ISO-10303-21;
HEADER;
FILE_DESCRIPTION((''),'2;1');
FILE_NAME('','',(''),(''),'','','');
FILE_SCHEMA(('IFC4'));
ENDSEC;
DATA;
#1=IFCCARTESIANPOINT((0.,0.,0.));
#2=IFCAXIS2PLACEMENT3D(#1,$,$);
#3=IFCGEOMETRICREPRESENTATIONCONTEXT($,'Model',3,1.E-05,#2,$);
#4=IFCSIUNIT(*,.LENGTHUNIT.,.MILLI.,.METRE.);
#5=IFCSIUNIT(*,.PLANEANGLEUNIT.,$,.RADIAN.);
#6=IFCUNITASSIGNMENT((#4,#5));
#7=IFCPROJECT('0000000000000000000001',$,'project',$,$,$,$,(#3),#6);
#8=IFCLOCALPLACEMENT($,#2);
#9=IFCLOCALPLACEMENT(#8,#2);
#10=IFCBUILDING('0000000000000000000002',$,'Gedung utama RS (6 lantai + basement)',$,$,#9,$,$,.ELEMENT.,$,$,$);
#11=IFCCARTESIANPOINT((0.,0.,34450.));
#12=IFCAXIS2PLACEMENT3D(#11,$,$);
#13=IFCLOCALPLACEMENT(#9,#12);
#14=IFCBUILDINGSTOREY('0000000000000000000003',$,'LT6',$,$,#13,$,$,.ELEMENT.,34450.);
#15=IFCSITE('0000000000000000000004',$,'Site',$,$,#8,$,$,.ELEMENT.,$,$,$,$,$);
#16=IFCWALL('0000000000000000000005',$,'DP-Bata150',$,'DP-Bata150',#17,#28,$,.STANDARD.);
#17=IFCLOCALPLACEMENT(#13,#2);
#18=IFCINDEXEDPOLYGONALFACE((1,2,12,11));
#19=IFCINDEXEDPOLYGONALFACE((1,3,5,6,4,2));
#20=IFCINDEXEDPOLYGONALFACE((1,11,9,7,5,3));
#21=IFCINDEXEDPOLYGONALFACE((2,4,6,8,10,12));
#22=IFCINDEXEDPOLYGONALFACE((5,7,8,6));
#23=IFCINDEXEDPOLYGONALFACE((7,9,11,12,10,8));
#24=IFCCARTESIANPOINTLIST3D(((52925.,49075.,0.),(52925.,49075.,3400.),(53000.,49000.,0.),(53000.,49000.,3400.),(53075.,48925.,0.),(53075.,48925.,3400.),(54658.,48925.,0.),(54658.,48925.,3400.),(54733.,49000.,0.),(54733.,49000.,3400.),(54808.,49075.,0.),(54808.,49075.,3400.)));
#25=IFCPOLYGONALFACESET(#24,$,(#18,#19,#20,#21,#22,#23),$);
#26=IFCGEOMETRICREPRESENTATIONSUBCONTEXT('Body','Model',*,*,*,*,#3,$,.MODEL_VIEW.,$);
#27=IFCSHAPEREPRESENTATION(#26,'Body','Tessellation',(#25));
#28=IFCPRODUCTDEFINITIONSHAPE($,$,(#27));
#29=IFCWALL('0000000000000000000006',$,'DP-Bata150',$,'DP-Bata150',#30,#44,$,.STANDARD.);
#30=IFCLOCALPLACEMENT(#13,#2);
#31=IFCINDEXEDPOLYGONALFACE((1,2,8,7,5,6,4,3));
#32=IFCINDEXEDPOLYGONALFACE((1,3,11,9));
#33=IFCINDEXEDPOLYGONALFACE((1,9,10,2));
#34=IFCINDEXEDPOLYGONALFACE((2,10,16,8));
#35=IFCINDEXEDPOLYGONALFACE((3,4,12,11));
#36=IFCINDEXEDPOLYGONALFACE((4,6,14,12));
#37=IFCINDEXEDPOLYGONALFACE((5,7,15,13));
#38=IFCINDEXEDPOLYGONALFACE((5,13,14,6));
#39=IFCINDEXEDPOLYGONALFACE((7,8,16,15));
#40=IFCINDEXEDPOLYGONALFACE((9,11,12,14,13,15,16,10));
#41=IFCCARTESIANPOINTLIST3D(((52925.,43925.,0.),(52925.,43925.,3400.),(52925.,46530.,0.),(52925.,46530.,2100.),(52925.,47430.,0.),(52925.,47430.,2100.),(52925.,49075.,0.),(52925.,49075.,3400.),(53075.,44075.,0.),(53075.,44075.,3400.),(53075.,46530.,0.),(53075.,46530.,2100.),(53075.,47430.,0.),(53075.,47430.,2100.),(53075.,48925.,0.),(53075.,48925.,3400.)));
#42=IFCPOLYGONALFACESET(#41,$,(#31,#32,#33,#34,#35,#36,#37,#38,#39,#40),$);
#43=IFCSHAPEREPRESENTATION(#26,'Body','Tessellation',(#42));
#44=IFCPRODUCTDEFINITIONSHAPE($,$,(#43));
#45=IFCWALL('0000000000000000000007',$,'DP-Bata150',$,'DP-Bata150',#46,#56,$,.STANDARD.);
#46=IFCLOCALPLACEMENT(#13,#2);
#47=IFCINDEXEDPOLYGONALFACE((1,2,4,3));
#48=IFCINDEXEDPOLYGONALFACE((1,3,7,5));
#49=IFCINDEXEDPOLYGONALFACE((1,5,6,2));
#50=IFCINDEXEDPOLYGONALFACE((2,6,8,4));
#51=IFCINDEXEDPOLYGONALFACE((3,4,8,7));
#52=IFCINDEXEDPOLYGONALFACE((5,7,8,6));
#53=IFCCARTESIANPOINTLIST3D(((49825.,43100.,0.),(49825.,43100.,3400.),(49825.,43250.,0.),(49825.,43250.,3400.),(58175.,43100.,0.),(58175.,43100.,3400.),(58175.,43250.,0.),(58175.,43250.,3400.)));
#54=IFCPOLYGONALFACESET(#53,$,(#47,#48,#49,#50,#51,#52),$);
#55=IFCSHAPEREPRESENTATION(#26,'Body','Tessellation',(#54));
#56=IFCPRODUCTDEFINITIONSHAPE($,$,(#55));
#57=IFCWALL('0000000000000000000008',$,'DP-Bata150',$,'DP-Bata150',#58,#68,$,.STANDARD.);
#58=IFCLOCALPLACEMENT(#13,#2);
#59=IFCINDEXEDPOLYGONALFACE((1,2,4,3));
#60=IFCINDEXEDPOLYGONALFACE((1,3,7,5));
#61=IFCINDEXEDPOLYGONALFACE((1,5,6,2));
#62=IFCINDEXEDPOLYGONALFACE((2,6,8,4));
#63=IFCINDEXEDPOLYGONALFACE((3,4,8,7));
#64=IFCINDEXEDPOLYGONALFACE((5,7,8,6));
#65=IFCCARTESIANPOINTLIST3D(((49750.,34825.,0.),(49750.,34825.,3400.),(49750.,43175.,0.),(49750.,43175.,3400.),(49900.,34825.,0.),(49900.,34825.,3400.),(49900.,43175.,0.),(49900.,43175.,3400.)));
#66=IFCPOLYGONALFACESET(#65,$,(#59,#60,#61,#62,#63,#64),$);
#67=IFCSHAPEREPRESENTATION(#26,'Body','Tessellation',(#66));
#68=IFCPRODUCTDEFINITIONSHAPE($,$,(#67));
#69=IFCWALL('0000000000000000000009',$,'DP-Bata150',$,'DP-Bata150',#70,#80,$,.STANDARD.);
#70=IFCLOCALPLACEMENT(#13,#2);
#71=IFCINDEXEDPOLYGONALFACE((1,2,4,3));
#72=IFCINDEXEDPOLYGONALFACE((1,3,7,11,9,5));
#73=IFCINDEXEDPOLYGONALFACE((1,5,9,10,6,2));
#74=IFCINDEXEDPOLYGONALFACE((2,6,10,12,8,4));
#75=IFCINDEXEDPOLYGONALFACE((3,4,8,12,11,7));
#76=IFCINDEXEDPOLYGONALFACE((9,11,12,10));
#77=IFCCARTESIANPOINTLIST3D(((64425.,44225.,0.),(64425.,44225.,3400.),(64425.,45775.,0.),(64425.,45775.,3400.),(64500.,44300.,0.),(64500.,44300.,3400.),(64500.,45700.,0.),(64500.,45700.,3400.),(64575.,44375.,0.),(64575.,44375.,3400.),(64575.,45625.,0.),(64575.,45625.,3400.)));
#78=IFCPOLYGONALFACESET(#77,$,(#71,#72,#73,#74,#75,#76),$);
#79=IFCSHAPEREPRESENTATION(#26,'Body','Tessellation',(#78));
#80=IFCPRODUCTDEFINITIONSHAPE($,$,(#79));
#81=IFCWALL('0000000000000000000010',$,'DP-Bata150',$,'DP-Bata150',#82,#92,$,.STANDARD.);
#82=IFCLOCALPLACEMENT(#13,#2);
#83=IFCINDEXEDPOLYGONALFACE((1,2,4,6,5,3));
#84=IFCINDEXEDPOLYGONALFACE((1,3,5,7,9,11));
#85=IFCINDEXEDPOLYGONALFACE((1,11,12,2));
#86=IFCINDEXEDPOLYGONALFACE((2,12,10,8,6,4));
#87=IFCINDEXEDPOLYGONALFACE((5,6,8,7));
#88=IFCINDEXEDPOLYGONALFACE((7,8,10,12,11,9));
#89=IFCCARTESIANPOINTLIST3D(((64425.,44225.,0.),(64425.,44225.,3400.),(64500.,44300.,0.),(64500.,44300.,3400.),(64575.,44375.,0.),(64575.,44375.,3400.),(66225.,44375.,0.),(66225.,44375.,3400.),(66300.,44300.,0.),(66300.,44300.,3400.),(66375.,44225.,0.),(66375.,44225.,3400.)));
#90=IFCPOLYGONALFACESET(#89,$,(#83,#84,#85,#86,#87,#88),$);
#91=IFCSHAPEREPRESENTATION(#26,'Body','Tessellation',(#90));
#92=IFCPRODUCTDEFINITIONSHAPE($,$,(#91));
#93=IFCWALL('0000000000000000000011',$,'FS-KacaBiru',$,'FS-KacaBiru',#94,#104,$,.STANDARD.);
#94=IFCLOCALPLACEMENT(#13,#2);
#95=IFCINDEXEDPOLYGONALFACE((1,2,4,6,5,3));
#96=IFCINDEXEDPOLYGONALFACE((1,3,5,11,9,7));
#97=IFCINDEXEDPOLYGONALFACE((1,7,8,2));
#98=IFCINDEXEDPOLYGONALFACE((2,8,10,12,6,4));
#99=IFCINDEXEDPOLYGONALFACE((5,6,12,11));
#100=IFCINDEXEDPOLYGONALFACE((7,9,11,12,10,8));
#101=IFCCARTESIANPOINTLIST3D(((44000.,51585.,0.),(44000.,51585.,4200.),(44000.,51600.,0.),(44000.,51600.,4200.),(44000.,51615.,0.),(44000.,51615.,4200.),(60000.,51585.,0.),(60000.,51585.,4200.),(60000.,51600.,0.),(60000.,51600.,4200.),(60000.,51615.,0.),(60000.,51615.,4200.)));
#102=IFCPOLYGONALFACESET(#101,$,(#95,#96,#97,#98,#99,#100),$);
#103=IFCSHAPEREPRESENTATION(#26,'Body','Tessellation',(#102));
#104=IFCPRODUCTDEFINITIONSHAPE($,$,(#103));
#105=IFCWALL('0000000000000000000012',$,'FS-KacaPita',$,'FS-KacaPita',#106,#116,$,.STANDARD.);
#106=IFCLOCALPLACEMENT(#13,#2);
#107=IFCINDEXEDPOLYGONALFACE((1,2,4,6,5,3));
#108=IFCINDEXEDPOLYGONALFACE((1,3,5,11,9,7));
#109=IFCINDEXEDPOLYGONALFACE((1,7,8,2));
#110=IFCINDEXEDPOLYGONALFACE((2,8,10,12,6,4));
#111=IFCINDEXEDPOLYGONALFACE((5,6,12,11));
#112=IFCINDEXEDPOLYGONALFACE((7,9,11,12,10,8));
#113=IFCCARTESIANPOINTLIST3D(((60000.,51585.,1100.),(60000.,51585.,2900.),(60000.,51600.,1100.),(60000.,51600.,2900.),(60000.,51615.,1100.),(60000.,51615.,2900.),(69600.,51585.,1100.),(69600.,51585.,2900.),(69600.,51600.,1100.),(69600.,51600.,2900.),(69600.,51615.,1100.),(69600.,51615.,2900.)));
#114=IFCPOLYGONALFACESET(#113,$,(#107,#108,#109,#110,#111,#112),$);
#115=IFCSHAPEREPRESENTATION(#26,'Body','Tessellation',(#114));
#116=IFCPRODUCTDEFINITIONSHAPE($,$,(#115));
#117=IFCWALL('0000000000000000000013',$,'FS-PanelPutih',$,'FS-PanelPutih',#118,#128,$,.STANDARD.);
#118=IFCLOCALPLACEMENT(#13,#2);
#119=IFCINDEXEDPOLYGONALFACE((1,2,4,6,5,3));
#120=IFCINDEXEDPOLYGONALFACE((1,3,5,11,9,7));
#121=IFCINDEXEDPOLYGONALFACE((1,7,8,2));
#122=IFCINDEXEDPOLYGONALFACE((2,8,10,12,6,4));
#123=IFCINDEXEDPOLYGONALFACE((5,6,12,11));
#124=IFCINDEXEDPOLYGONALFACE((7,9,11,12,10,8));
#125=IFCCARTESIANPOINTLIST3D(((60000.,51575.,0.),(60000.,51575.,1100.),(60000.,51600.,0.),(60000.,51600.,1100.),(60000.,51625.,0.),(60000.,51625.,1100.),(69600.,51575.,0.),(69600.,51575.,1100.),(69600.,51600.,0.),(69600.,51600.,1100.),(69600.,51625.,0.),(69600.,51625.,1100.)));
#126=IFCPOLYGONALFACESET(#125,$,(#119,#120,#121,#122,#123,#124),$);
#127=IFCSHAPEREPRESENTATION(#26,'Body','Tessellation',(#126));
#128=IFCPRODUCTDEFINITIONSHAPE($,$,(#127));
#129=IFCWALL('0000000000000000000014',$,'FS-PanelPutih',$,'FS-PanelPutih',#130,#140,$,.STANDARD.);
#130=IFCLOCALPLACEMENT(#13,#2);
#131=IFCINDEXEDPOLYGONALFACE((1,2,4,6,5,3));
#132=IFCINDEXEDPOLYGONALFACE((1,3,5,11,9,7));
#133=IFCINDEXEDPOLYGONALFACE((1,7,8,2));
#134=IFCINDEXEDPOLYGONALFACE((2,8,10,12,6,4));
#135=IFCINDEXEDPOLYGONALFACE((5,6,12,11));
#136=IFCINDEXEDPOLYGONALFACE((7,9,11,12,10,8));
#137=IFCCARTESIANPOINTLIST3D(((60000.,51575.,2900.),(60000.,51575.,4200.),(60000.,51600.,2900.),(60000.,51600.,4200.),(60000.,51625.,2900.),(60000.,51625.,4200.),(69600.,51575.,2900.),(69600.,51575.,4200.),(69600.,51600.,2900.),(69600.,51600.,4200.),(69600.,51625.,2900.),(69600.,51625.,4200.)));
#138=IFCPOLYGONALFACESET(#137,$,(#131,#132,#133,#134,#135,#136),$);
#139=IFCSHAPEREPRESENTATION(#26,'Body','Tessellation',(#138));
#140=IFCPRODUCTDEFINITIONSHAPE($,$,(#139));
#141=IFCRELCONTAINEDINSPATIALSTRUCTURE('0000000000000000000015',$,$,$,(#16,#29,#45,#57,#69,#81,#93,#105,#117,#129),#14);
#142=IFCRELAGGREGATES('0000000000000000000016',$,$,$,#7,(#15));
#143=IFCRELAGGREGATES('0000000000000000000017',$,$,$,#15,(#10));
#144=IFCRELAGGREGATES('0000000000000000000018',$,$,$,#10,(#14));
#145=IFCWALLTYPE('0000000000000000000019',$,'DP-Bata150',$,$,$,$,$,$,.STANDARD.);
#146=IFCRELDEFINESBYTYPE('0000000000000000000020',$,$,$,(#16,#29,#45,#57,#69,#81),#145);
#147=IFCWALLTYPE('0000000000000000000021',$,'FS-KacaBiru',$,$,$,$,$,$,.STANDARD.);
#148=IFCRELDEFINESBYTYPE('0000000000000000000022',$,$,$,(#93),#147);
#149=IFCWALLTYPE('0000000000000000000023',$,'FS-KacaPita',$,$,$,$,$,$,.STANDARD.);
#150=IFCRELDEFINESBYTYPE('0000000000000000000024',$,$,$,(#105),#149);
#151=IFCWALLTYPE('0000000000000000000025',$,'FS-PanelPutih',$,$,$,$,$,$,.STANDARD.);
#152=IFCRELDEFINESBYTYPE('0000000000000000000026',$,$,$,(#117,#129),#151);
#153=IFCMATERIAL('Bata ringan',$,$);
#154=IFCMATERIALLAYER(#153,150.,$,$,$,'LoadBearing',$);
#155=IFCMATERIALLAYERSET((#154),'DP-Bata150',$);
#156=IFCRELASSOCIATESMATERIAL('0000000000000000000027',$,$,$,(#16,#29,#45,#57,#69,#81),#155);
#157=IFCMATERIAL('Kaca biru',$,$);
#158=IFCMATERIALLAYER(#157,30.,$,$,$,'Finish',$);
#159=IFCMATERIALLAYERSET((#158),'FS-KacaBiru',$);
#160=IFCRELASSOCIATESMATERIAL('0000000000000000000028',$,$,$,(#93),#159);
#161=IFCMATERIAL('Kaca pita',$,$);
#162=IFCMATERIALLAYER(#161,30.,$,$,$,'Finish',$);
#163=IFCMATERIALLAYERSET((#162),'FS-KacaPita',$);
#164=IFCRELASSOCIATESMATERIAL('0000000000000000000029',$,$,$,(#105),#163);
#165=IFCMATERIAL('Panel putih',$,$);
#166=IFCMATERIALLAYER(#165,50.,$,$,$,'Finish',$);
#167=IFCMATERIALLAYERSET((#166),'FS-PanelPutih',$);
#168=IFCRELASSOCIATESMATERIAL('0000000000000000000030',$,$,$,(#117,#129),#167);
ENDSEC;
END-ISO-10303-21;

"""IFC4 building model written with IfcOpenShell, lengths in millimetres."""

from ifc_helpers import new_model, si_unit, frame, frame_2d, origin, place, context, subcontext, project, spatial, polyline, rectangle, outline, extrude, material, layer, layer_set, layer_usage, type_object, element, save


model = new_model("IFC4")

# Units and contexts
model_context = context("Model", 3, precision=1e-05, world=origin())
body_context = subcontext(model_context, "Body", "Model", "MODEL_VIEW")
ifc_project = project(units=[si_unit("LENGTHUNIT", "METRE", prefix="MILLI"), si_unit("PLANEANGLEUNIT", "RADIAN")], contexts=[model_context])

# Site, building, storey
site_placement = place(None, origin())
site = spatial("IfcSite", under=ifc_project, at=site_placement, Name="Site", CompositionType="ELEMENT")
building_placement = place(site_placement, origin())
building = spatial("IfcBuilding", under=site, at=building_placement, Name="Gedung utama RS (6 lantai + basement)", CompositionType="ELEMENT")
storey_placement = place(building_placement, frame((0.0, 0.0, 34450.0)))
storey = spatial("IfcBuildingStorey", under=building, at=storey_placement, Name="LT6", CompositionType="ELEMENT", Elevation=34450.0)

# Shared definitions
ifc_material_1 = material(Name="Bata ringan")
ifc_layer_1 = layer(ifc_material_1, 150.0, Category="LoadBearing")
ifc_layer_set_1 = layer_set([ifc_layer_1], Name="DP-Bata150")
ifc_layer_usage_1 = layer_usage(ifc_layer_set_1, "AXIS2", "NEGATIVE", 75.0)
wall_type_1 = type_object("IfcWallType", Name="DP-Bata150", PredefinedType="STANDARD")

# Wall
wall_1_placement = place(storey_placement, frame((54733.0, 49000.0, 0.0), z_axis=(0.0, 0.0, 1.0), x_axis=(-1.0, 0.0, 0.0)))
element("IfcWall", 1, at=wall_1_placement, inside=storey, type_object=wall_type_1, material=ifc_layer_usage_1, Name="DP-Bata150", ObjectType="DP-Bata150", PredefinedType="STANDARD", context=body_context, shape_type="SweptSolid", body=[
    extrude(outline(polyline([(-75.0, -75.0), (0.0, 0.0), (75.0, 75.0), (1658.0, 75.0), (1733.0, 0.0), (1808.0, -75.0), (-75.0, -75.0)])), origin(), (0.0, 0.0, 1.0), 3400.0),
])

# Wall, opening
wall_2_placement = place(storey_placement, frame((53000.0, 49000.0, 0.0), z_axis=(0.0, 0.0, 1.0), x_axis=(0.0, -1.0, 0.0)))
wall_2 = element("IfcWall", 2, at=wall_2_placement, inside=storey, type_object=wall_type_1, material=ifc_layer_usage_1, Name="DP-Bata150", ObjectType="DP-Bata150", PredefinedType="STANDARD", context=body_context, shape_type="SweptSolid", body=[
    extrude(outline(polyline([(-75.0, -75.0), (0.0, 0.0), (75.0, 75.0), (4925.0, 75.0), (5000.0, 0.0), (5075.0, -75.0), (-75.0, -75.0)])), origin(), (0.0, 0.0, 1.0), 3400.0),
])
opening_1_placement = place(wall_2_placement, frame((1570.0, 0.0, 0.0), z_axis=(0.0, 0.0, 1.0), x_axis=(1.0, 0.0, 0.0)))
element("IfcOpeningElement", 3, at=opening_1_placement, cuts=wall_2, PredefinedType="OPENING", context=body_context, shape_type="SweptSolid", body=[
    extrude(rectangle(XDim=900.0, YDim=170.0, at=frame_2d((450.0, 0.0))), origin(), (0.0, 0.0, 1.0), 2100.0),
])

# Walls
for number, where, z_axis, x_axis, name in (
    (4, (58175.0, 43175.0, 0.0), (0.0, 0.0, 1.0), (-1.0, 0.0, 0.0), "DP-Bata150"),
    (5, (49825.0, 43175.0, 0.0), (0.0, 0.0, 1.0), (0.0, -1.0, 0.0), "DP-Bata150"),
):
    element("IfcWall", number, at=place(storey_placement, frame(where, z_axis=z_axis, x_axis=x_axis)), inside=storey, type_object=wall_type_1, material=ifc_layer_usage_1, Name=name, ObjectType="DP-Bata150", PredefinedType="STANDARD", context=body_context, shape_type="SweptSolid", body=[
        extrude(outline(polyline([(0.0, -75.0), (0.0, 75.0), (8350.0, 75.0), (8350.0, -75.0), (0.0, -75.0)])), origin(), (0.0, 0.0, 1.0), 3400.0),
    ])
wall_3_placement = place(storey_placement, frame((64500.0, 45700.0, 0.0), z_axis=(0.0, 0.0, 1.0), x_axis=(0.0, -1.0, 0.0)))
element("IfcWall", 6, at=wall_3_placement, inside=storey, type_object=wall_type_1, material=ifc_layer_usage_1, Name="DP-Bata150", ObjectType="DP-Bata150", PredefinedType="STANDARD", context=body_context, shape_type="SweptSolid", body=[
    extrude(outline(polyline([(-75.0, -75.0), (0.0, 0.0), (75.0, 75.0), (1325.0, 75.0), (1400.0, 0.0), (1475.0, -75.0), (-75.0, -75.0)])), origin(), (0.0, 0.0, 1.0), 3400.0),
])
wall_4_placement = place(storey_placement, frame((64500.0, 44300.0, 0.0), z_axis=(0.0, 0.0, 1.0), x_axis=(1.0, 0.0, 0.0)))
element("IfcWall", 7, at=wall_4_placement, inside=storey, type_object=wall_type_1, material=ifc_layer_usage_1, Name="DP-Bata150", ObjectType="DP-Bata150", PredefinedType="STANDARD", context=body_context, shape_type="SweptSolid", body=[
    extrude(outline(polyline([(-75.0, -75.0), (0.0, 0.0), (75.0, 75.0), (1725.0, 75.0), (1800.0, 0.0), (1875.0, -75.0), (-75.0, -75.0)])), origin(), (0.0, 0.0, 1.0), 3400.0),
])
ifc_material_2 = material(Name="Kaca biru")
ifc_layer_2 = layer(ifc_material_2, 30.0, Category="Finish")
ifc_layer_set_2 = layer_set([ifc_layer_2], Name="FS-KacaBiru")
ifc_layer_usage_2 = layer_usage(ifc_layer_set_2, "AXIS2", "NEGATIVE", 15.0)
wall_type_2 = type_object("IfcWallType", Name="FS-KacaBiru", PredefinedType="STANDARD")
wall_5_placement = place(storey_placement, frame((44000.0, 51600.0, 0.0), z_axis=(0.0, 0.0, 1.0), x_axis=(1.0, 0.0, 0.0)))
element("IfcWall", 8, at=wall_5_placement, inside=storey, type_object=wall_type_2, material=ifc_layer_usage_2, Name="FS-KacaBiru", ObjectType="FS-KacaBiru", PredefinedType="STANDARD", context=body_context, shape_type="SweptSolid", body=[
    extrude(outline(polyline([(0.0, -15.0), (0.0, 0.0), (0.0, 15.0), (16000.0, 15.0), (16000.0, 0.0), (16000.0, -15.0), (0.0, -15.0)])), origin(), (0.0, 0.0, 1.0), 4200.0),
])
ifc_material_3 = material(Name="Kaca pita")
ifc_layer_3 = layer(ifc_material_3, 30.0, Category="Finish")
ifc_layer_set_3 = layer_set([ifc_layer_3], Name="FS-KacaPita")
ifc_layer_usage_3 = layer_usage(ifc_layer_set_3, "AXIS2", "NEGATIVE", 15.0)
wall_type_3 = type_object("IfcWallType", Name="FS-KacaPita", PredefinedType="STANDARD")
wall_6_placement = place(storey_placement, frame((60000.0, 51600.0, 1100.0), z_axis=(0.0, 0.0, 1.0), x_axis=(1.0, 0.0, 0.0)))
element("IfcWall", 9, at=wall_6_placement, inside=storey, type_object=wall_type_3, material=ifc_layer_usage_3, Name="FS-KacaPita", ObjectType="FS-KacaPita", PredefinedType="STANDARD", context=body_context, shape_type="SweptSolid", body=[
    extrude(outline(polyline([(0.0, -15.0), (0.0, 0.0), (0.0, 15.0), (9600.0, 15.0), (9600.0, 0.0), (9600.0, -15.0), (0.0, -15.0)])), origin(), (0.0, 0.0, 1.0), 1800.0),
])
ifc_material_4 = material(Name="Panel putih")
ifc_layer_4 = layer(ifc_material_4, 50.0, Category="Finish")
ifc_layer_set_4 = layer_set([ifc_layer_4], Name="FS-PanelPutih")
ifc_layer_usage_4 = layer_usage(ifc_layer_set_4, "AXIS2", "NEGATIVE", 25.0)
wall_type_4 = type_object("IfcWallType", Name="FS-PanelPutih", PredefinedType="STANDARD")
wall_7_placement = place(storey_placement, frame((60000.0, 51600.0, 0.0), z_axis=(0.0, 0.0, 1.0), x_axis=(1.0, 0.0, 0.0)))
element("IfcWall", 10, at=wall_7_placement, inside=storey, type_object=wall_type_4, material=ifc_layer_usage_4, Name="FS-PanelPutih", ObjectType="FS-PanelPutih", PredefinedType="STANDARD", context=body_context, shape_type="SweptSolid", body=[
    extrude(outline(polyline([(0.0, -25.0), (0.0, 0.0), (0.0, 25.0), (9600.0, 25.0), (9600.0, 0.0), (9600.0, -25.0), (0.0, -25.0)])), origin(), (0.0, 0.0, 1.0), 1100.0),
])
wall_8_placement = place(storey_placement, frame((60000.0, 51600.0, 2900.0), z_axis=(0.0, 0.0, 1.0), x_axis=(1.0, 0.0, 0.0)))
element("IfcWall", 11, at=wall_8_placement, inside=storey, type_object=wall_type_4, material=ifc_layer_usage_4, Name="FS-PanelPutih", ObjectType="FS-PanelPutih", PredefinedType="STANDARD", context=body_context, shape_type="SweptSolid", body=[
    extrude(outline(polyline([(0.0, -25.0), (0.0, 0.0), (0.0, 25.0), (9600.0, 25.0), (9600.0, 0.0), (9600.0, -25.0), (0.0, -25.0)])), origin(), (0.0, 0.0, 1.0), 1300.0),
])

save(model, "model.ifc")
